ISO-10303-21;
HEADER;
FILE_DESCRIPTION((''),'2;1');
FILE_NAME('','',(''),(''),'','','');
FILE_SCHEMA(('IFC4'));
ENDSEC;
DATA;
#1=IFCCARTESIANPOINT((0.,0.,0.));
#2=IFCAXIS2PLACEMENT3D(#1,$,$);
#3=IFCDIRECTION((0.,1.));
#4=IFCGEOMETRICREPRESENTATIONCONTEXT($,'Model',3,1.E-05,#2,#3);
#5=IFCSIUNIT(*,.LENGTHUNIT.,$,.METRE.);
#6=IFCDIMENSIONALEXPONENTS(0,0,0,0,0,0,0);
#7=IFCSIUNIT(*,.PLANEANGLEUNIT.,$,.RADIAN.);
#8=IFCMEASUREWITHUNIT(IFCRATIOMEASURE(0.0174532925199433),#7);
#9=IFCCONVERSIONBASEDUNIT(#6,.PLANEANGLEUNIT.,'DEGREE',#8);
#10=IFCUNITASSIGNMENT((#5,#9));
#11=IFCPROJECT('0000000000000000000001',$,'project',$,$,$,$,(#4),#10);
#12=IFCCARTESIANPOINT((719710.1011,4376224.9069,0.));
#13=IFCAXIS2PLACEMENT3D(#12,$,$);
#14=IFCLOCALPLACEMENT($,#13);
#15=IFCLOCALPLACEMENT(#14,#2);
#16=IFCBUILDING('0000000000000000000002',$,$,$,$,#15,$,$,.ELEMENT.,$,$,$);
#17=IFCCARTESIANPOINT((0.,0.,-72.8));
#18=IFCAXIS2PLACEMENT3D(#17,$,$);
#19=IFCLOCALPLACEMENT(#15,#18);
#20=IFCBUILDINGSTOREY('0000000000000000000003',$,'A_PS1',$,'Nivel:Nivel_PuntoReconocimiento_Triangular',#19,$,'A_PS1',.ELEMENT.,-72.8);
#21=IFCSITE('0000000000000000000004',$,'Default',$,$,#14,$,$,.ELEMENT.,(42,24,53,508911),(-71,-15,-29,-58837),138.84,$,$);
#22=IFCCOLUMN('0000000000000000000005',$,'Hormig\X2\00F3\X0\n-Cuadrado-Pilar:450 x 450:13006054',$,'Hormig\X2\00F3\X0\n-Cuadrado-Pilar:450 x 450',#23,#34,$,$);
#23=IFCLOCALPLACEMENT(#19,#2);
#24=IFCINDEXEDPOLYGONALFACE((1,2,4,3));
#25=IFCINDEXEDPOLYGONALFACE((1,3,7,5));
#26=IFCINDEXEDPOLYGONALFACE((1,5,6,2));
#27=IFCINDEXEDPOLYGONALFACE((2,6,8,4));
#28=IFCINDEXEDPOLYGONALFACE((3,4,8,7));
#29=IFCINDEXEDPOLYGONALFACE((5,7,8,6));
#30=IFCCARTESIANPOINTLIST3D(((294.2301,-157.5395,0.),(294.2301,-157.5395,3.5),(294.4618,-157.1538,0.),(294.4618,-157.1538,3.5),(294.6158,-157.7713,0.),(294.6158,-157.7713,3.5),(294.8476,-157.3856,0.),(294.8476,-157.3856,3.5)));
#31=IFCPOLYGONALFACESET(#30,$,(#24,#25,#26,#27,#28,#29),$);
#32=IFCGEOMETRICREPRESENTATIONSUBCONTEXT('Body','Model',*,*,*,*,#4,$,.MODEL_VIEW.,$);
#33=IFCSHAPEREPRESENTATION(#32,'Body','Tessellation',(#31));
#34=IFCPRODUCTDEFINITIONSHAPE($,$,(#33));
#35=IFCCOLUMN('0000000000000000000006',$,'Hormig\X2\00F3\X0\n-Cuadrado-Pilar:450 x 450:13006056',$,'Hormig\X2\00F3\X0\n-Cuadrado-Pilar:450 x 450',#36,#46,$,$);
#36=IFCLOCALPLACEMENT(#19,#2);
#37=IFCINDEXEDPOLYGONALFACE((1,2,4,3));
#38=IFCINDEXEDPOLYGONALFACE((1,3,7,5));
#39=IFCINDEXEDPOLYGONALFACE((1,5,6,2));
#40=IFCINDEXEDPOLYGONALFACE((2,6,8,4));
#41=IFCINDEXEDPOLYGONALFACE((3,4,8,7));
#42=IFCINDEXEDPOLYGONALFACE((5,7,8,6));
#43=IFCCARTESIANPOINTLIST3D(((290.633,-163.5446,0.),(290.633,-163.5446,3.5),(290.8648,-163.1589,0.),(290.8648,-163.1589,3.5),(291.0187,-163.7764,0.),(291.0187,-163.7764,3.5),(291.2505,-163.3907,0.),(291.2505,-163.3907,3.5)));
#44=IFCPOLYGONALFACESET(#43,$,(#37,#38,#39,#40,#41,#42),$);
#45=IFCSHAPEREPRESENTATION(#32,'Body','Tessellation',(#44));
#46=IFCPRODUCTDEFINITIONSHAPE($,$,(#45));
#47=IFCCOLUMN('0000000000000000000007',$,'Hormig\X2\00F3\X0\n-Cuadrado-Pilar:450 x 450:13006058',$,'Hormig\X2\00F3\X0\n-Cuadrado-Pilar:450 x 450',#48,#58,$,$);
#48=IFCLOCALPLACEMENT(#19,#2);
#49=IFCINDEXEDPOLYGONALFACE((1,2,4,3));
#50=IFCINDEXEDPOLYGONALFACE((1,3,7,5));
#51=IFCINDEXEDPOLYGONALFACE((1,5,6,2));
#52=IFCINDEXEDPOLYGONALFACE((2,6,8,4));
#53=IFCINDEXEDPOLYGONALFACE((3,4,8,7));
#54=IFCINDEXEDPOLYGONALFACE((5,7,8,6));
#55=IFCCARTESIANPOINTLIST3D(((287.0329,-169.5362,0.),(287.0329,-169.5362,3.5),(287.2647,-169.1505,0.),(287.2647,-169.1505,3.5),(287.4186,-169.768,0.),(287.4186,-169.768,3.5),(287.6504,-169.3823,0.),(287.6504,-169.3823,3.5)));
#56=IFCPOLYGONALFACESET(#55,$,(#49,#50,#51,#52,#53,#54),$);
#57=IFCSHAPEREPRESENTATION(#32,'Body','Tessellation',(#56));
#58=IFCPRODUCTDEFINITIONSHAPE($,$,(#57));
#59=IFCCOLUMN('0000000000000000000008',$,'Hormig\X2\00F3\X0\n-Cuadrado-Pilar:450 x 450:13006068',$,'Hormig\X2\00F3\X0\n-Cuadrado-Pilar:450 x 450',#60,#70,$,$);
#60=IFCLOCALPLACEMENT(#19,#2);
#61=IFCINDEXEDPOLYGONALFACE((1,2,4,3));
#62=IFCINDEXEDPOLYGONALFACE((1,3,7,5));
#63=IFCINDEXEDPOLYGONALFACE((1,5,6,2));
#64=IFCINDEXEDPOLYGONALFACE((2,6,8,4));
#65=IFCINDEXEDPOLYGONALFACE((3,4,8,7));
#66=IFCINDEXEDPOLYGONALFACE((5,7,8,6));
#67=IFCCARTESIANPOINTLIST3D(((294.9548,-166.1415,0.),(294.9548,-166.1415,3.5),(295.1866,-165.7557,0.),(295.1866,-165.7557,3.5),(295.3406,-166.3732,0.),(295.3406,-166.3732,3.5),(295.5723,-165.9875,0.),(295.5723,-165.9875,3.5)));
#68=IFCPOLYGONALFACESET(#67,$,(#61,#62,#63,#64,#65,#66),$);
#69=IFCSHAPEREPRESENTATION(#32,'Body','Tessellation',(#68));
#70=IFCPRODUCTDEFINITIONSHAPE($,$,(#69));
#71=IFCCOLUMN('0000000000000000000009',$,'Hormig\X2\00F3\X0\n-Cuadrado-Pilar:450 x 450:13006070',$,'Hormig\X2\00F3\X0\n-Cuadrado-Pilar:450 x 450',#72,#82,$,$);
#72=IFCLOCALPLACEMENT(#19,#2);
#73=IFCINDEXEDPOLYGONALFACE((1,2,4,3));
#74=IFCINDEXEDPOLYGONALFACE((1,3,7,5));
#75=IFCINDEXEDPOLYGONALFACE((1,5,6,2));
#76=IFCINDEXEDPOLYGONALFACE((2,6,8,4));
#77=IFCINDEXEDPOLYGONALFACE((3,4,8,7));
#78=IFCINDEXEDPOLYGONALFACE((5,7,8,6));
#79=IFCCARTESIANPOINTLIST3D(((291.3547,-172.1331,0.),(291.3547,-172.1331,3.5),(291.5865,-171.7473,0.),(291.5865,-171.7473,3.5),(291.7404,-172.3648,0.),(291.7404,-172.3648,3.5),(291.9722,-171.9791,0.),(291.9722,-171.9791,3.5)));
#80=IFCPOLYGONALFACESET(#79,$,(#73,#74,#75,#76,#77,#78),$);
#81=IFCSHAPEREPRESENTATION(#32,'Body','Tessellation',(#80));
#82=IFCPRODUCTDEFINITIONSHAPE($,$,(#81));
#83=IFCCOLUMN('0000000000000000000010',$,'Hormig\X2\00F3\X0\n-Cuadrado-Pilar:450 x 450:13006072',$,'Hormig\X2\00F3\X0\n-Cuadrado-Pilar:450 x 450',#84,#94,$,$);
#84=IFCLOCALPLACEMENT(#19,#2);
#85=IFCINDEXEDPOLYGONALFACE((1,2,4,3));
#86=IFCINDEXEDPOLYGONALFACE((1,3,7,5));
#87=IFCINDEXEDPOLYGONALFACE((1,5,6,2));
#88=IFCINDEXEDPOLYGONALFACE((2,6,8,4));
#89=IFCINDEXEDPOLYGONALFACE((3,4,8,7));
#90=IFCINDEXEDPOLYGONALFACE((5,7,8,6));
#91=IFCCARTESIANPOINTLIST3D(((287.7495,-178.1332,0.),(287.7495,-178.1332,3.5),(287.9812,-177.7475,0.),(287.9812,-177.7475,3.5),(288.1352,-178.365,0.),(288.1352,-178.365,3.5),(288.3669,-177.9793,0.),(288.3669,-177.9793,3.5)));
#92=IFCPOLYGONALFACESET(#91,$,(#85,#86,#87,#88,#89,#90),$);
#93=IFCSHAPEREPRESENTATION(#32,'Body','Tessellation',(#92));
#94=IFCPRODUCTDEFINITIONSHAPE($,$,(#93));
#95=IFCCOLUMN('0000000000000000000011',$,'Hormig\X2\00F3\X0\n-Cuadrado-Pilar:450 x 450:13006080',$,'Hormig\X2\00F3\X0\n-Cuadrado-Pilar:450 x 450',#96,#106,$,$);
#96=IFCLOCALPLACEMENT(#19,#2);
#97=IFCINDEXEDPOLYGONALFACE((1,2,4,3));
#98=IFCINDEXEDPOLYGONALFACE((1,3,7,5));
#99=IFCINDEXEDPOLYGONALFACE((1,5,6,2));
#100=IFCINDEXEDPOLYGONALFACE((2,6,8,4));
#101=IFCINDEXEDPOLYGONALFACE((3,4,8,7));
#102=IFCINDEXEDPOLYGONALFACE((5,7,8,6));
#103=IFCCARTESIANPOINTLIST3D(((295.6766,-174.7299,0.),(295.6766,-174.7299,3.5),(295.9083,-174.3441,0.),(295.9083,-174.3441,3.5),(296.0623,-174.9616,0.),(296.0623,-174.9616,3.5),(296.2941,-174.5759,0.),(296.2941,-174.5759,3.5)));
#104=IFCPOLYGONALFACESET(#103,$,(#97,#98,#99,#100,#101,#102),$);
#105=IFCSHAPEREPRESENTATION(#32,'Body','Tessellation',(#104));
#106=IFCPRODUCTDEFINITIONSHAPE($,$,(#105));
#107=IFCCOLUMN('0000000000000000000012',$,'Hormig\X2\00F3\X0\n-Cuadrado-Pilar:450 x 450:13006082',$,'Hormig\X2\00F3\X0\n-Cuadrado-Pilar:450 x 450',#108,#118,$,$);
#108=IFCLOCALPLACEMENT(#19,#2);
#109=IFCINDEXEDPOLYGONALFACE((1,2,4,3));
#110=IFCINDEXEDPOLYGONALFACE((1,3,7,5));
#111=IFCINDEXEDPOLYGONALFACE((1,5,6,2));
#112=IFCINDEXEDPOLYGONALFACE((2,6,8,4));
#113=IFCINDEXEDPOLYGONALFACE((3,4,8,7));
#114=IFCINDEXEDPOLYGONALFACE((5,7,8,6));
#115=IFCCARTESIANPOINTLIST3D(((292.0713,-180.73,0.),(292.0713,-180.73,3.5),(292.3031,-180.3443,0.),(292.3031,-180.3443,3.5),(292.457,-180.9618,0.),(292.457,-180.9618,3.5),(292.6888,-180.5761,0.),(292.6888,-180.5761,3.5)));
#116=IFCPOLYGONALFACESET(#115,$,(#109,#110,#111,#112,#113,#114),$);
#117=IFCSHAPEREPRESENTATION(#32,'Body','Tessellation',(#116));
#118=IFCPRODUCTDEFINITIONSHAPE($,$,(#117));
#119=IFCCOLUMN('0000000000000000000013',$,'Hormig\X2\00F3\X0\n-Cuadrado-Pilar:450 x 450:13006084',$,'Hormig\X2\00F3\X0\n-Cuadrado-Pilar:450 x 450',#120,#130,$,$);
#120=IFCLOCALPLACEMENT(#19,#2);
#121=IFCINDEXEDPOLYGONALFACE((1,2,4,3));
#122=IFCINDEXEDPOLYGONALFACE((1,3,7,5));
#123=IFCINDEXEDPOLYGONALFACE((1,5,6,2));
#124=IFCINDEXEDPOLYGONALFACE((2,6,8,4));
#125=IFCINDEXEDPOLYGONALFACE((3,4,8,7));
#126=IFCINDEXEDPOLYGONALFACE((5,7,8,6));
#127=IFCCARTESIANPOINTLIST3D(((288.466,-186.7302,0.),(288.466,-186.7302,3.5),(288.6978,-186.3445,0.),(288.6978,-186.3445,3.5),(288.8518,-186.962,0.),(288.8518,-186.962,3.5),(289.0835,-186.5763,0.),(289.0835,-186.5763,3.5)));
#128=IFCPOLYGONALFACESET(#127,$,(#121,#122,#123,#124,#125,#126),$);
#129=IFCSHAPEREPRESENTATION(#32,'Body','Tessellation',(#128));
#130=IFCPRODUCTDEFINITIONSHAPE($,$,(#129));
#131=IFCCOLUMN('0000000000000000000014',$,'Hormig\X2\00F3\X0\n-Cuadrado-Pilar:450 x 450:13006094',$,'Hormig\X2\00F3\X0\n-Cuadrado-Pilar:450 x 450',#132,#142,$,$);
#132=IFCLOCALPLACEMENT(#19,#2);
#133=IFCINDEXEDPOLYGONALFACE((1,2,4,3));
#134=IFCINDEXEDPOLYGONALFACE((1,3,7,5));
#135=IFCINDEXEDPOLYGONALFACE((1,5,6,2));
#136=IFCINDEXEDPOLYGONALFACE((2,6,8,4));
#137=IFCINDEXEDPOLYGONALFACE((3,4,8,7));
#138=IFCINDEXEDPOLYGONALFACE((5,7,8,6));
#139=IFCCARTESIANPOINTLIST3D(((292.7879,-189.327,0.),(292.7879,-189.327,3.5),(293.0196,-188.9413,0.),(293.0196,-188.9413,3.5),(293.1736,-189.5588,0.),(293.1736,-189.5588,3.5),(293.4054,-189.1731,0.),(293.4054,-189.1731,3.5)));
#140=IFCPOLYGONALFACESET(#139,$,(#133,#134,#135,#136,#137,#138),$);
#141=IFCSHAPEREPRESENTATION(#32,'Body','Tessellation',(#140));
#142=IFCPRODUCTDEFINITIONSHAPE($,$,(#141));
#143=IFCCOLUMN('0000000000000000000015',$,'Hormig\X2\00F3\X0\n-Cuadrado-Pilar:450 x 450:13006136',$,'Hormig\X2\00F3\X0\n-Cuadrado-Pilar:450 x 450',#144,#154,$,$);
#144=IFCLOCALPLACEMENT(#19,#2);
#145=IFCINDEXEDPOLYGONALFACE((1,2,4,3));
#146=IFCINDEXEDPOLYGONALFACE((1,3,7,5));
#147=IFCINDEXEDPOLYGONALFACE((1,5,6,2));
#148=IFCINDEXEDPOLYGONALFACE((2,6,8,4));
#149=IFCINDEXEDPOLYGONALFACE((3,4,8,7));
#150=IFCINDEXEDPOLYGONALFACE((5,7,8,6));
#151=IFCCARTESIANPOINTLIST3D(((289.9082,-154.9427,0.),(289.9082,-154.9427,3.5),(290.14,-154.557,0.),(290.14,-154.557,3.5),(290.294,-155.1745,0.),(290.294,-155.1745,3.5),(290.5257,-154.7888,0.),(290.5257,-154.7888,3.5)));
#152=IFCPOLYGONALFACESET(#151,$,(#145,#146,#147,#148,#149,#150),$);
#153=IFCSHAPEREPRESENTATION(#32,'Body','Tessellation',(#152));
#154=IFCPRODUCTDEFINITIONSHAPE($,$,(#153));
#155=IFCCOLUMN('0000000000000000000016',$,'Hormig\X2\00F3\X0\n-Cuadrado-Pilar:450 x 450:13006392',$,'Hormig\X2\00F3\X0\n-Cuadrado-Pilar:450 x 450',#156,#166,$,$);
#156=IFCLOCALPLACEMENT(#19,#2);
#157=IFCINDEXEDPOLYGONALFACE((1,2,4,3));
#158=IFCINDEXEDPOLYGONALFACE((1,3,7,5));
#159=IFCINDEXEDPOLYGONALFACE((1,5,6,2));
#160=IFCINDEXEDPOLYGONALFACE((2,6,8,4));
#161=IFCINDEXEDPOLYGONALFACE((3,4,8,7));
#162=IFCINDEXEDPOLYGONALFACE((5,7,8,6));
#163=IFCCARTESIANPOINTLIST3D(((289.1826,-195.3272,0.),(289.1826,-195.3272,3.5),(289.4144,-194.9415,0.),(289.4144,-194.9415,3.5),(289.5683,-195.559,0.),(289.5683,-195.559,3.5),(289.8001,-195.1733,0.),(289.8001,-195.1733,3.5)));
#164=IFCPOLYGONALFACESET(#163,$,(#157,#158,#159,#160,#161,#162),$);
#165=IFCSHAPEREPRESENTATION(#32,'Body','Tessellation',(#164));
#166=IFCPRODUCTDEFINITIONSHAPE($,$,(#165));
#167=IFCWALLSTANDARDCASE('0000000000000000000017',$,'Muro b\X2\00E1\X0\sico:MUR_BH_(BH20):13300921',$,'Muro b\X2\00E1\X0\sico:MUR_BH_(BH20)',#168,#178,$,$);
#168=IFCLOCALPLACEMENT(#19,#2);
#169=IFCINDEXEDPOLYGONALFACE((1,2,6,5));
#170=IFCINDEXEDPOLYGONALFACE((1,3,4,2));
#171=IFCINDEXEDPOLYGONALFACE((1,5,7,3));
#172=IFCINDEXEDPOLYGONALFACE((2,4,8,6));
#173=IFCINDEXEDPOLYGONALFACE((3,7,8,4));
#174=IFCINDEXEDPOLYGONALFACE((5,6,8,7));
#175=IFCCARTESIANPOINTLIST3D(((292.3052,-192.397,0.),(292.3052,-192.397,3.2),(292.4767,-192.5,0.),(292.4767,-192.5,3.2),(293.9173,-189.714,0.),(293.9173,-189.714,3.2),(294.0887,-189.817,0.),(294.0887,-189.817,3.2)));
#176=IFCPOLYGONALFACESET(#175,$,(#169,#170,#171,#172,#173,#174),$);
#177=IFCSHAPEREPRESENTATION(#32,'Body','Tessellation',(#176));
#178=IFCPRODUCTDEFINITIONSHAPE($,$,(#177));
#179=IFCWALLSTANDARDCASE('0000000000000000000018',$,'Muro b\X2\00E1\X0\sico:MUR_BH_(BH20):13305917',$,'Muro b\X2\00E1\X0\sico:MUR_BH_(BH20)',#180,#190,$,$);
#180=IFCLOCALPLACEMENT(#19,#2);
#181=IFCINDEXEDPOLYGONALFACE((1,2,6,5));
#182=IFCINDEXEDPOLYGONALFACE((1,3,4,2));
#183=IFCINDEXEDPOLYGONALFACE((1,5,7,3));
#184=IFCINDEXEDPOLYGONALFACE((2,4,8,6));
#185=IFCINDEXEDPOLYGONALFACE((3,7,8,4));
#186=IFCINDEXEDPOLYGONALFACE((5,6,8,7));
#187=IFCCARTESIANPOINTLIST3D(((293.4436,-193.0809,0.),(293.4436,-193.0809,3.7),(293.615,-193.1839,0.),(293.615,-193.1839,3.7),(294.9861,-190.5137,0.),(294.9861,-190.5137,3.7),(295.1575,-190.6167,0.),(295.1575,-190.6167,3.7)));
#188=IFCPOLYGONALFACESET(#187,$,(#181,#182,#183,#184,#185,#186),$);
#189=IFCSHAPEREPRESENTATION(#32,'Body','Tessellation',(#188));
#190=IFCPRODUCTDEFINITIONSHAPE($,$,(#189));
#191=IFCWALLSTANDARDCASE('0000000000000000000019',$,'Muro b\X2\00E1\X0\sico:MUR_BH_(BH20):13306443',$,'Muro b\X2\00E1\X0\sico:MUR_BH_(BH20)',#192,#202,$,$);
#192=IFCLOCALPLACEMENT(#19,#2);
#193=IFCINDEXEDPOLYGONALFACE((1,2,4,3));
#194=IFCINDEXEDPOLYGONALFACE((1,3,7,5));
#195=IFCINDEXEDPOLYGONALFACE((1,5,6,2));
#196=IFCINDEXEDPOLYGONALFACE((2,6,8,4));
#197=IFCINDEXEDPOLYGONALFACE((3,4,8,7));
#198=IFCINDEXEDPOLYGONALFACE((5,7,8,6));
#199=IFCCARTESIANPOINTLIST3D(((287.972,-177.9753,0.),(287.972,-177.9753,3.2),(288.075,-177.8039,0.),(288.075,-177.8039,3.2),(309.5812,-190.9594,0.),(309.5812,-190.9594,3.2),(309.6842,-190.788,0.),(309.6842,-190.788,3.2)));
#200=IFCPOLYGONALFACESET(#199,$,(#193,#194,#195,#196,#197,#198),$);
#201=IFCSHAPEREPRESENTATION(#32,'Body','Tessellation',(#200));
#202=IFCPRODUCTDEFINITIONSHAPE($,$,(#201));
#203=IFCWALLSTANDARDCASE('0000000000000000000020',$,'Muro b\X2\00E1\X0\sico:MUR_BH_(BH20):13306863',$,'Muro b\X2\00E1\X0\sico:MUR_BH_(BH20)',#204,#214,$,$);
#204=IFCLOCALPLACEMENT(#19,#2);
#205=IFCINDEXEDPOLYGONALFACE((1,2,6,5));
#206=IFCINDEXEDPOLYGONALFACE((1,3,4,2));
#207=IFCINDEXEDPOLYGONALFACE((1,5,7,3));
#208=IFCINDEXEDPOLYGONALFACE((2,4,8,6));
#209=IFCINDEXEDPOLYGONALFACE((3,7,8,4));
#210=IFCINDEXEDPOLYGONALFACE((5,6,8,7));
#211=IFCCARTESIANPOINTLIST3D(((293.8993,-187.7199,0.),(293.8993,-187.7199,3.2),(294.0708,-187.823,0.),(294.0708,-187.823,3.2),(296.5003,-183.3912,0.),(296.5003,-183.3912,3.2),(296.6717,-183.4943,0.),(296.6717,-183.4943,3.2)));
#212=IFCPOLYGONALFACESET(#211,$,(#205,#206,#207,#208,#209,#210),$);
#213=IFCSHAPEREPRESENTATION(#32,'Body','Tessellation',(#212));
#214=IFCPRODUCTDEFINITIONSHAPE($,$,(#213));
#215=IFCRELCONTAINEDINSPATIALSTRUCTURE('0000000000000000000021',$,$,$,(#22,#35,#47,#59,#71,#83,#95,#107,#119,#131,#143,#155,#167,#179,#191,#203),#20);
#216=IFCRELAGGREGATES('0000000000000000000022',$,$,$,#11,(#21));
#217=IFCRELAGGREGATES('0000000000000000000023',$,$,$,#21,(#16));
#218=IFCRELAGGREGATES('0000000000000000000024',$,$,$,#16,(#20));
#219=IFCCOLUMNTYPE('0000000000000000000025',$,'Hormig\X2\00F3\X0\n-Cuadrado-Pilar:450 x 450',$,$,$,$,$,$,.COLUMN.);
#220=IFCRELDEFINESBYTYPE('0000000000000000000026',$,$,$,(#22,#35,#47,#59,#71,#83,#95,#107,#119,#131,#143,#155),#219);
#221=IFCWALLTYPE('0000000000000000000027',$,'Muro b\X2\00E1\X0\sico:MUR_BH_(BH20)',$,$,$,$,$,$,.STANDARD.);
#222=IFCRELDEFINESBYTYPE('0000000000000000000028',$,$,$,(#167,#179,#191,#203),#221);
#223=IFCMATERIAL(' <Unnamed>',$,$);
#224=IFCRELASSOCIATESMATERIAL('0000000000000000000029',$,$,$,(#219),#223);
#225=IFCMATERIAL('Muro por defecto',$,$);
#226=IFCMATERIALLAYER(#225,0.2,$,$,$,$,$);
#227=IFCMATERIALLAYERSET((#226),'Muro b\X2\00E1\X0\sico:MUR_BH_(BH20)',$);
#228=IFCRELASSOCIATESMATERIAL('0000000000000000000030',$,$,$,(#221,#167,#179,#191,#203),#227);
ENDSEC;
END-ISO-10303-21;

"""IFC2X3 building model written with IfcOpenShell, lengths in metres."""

from ifc_helpers import new_model, entity, si_unit, converted_unit, direction, frame, frame_2d, origin, origin_2d_with_axis, place, context, subcontext, project, spatial, rectangle, extrude, source, transform, mapped, material, layer, layer_set, layer_usage, type_object, type_shapes, element, save


model = new_model("IFC2X3")

# Units and contexts
model_context = context("Model", 3, precision=1e-05, world=origin(), true_north=direction((0.0, 1.0)))
body_context = subcontext(model_context, "Body", "Model", "MODEL_VIEW")
ifc_project = project(units=[si_unit("LENGTHUNIT", "METRE"), converted_unit("PLANEANGLEUNIT", "DEGREE", entity("IfcRatioMeasure", 0.0174532925199433), si_unit("PLANEANGLEUNIT", "RADIAN"), dimensions=[0, 0, 0, 0, 0, 0, 0])], contexts=[model_context])

# Site, building, storey
site_placement = place(None, frame((719710.1011, 4376224.9069, 0.0)))
site = spatial("IfcSite", under=ifc_project, at=site_placement, Name="Default", CompositionType="ELEMENT", RefLatitude=(42, 24, 53, 508911), RefLongitude=(-71, -15, -29, -58837), RefElevation=138.84)
building_placement = place(site_placement, origin())
building = spatial("IfcBuilding", under=site, at=building_placement, CompositionType="ELEMENT")
storey_placement = place(building_placement, frame((0.0, 0.0, -72.8)))
storey = spatial("IfcBuildingStorey", under=building, at=storey_placement, Name="A_PS1", ObjectType="Nivel:Nivel_PuntoReconocimiento_Triangular", LongName="A_PS1", CompositionType="ELEMENT", Elevation=-72.8)

# Columns
ifc_material_1 = material(Name=" <Unnamed>")
column_type = type_object("IfcColumnType", Name="Hormigón-Cuadrado-Pilar:450 x 450", PredefinedType="COLUMN", material=ifc_material_1)
shared_shape = source(origin(), body_context, "Body", "SweptSolid", [
    extrude(rectangle(XDim=0.45, YDim=0.45, at=origin_2d_with_axis()), frame((0.0, 0.0, -72.8), z_axis=(0.0, 0.0, 1.0), x_axis=(0.0, -1.0, 0.0)), (0.0, 0.0, 1.0), 3.5),
])
type_shapes(column_type, [shared_shape])
for number, where, z_axis, x_axis, name in (
    (1, (294.5388, -157.4626, 72.8), (0.0, 0.0, 1.0), (0.857167, -0.515038, 0.0), "Hormigón-Cuadrado-Pilar:450 x 450:13006054"),
    (2, (290.9417, -163.4677, 72.8), (0.0, 0.0, 1.0), (0.857167, -0.515038, 0.0), "Hormigón-Cuadrado-Pilar:450 x 450:13006056"),
    (3, (287.3416, -169.4593, 72.8), (0.0, 0.0, 1.0), (0.857167, -0.515038, 0.0), "Hormigón-Cuadrado-Pilar:450 x 450:13006058"),
    (4, (295.2636, -166.0645, 72.8), (0.0, 0.0, 1.0), (0.857167, -0.515038, 0.0), "Hormigón-Cuadrado-Pilar:450 x 450:13006068"),
    (5, (291.6635, -172.0561, 72.8), (0.0, 0.0, 1.0), (0.857167, -0.515038, 0.0), "Hormigón-Cuadrado-Pilar:450 x 450:13006070"),
    (6, (288.0582, -178.0562, 72.8), (0.0, 0.0, 1.0), (0.857167, -0.515038, 0.0), "Hormigón-Cuadrado-Pilar:450 x 450:13006072"),
    (7, (295.9853, -174.6529, 72.8), (0.0, 0.0, 1.0), (0.857167, -0.515038, 0.0), "Hormigón-Cuadrado-Pilar:450 x 450:13006080"),
    (8, (292.38, -180.6531, 72.8), (0.0, 0.0, 1.0), (0.857167, -0.515038, 0.0), "Hormigón-Cuadrado-Pilar:450 x 450:13006082"),
    (9, (288.7748, -186.6532, 72.8), (0.0, 0.0, 1.0), (0.857167, -0.515038, 0.0), "Hormigón-Cuadrado-Pilar:450 x 450:13006084"),
    (10, (293.0966, -189.2501, 72.8), (0.0, 0.0, 1.0), (0.857167, -0.515038, 0.0), "Hormigón-Cuadrado-Pilar:450 x 450:13006094"),
    (11, (290.217, -154.8657, 72.8), (0.0, 0.0, 1.0), (0.857167, -0.515038, 0.0), "Hormigón-Cuadrado-Pilar:450 x 450:13006136"),
    (12, (289.4913, -195.2502, 72.8), (0.0, 0.0, 1.0), (0.857167, -0.515038, 0.0), "Hormigón-Cuadrado-Pilar:450 x 450:13006392"),
):
    element("IfcColumn", number, at=place(storey_placement, frame(where, z_axis=z_axis, x_axis=x_axis)), inside=storey, type_object=column_type, Name=name, ObjectType="Hormigón-Cuadrado-Pilar:450 x 450", context=body_context, shape_type="MappedRepresentation", body=[
        mapped(shared_shape, transform((0.0, 0.0, 0.0), scale=1.0)),
    ])

# Shared definitions
ifc_material_2 = material(Name="Muro por defecto")
ifc_layer = layer(ifc_material_2, 0.2)
ifc_layer_set = layer_set([ifc_layer], Name="Muro básico:MUR_BH_(BH20)")
wall_type = type_object("IfcWallType", Name="Muro básico:MUR_BH_(BH20)", PredefinedType="STANDARD", material=ifc_layer_set)

# Walls
ifc_layer_usage_1 = layer_usage(ifc_layer_set, "AXIS2", "NEGATIVE", 0.1)
wall_1_placement = place(storey_placement, frame((294.003, -189.7655, 0.0), z_axis=(0.0, 0.0, 1.0), x_axis=(-0.515038, -0.857167, 0.0)))
element("IfcWallStandardCase", 13, at=wall_1_placement, inside=storey, type_object=wall_type, material=ifc_layer_usage_1, Name="Muro básico:MUR_BH_(BH20):13300921", ObjectType="Muro básico:MUR_BH_(BH20)", context=body_context, shape_type="SweptSolid", body=[
    extrude(rectangle(XDim=3.13, YDim=0.2, at=frame_2d((1.565, 0.0), x_axis=(-1.0, 0.0))), origin(), (0.0, 0.0, 1.0), 3.2),
])
ifc_layer_usage_2 = layer_usage(ifc_layer_set, "AXIS2", "NEGATIVE", 0.1)
wall_2_placement = place(storey_placement, frame((295.0718, -190.5652, 0.0), z_axis=(0.0, 0.0, 1.0), x_axis=(-0.515038, -0.857167, 0.0)))
element("IfcWallStandardCase", 14, at=wall_2_placement, inside=storey, type_object=wall_type, material=ifc_layer_usage_2, Name="Muro básico:MUR_BH_(BH20):13305917", ObjectType="Muro básico:MUR_BH_(BH20)", context=body_context, shape_type="SweptSolid", body=[
    extrude(rectangle(XDim=2.995, YDim=0.2, at=frame_2d((1.4975, 0.0), x_axis=(-1.0, 0.0))), origin(), (0.0, 0.0, 1.0), 3.7),
])
ifc_layer_usage_3 = layer_usage(ifc_layer_set, "AXIS2", "NEGATIVE", 0.1)
wall_3_placement = place(storey_placement, frame((288.0235, -177.8896, 0.0), z_axis=(0.0, 0.0, 1.0), x_axis=(0.857167, -0.515038, 0.0)))
element("IfcWallStandardCase", 15, at=wall_3_placement, inside=storey, type_object=wall_type, material=ifc_layer_usage_3, Name="Muro básico:MUR_BH_(BH20):13306443", ObjectType="Muro básico:MUR_BH_(BH20)", context=body_context, shape_type="SweptSolid", body=[
    extrude(rectangle(XDim=25.21, YDim=0.2, at=frame_2d((12.605, 0.0), x_axis=(-1.0, 0.0))), origin(), (0.0, 0.0, 1.0), 3.2),
])

# Wall
ifc_layer_usage_4 = layer_usage(ifc_layer_set, "AXIS2", "NEGATIVE", 0.1)
wall_4_placement = place(storey_placement, frame((296.586, -183.4428, 0.0), z_axis=(0.0, 0.0, 1.0), x_axis=(-0.515038, -0.857167, 0.0)))
element("IfcWallStandardCase", 16, at=wall_4_placement, inside=storey, type_object=wall_type, material=ifc_layer_usage_4, Name="Muro básico:MUR_BH_(BH20):13306863", ObjectType="Muro básico:MUR_BH_(BH20)", context=body_context, shape_type="SweptSolid", body=[
    extrude(rectangle(XDim=5.05, YDim=0.2, at=frame_2d((2.525, 0.0), x_axis=(-1.0, 0.0))), origin(), (0.0, 0.0, 1.0), 3.2),
])

save(model, "model.ifc")
